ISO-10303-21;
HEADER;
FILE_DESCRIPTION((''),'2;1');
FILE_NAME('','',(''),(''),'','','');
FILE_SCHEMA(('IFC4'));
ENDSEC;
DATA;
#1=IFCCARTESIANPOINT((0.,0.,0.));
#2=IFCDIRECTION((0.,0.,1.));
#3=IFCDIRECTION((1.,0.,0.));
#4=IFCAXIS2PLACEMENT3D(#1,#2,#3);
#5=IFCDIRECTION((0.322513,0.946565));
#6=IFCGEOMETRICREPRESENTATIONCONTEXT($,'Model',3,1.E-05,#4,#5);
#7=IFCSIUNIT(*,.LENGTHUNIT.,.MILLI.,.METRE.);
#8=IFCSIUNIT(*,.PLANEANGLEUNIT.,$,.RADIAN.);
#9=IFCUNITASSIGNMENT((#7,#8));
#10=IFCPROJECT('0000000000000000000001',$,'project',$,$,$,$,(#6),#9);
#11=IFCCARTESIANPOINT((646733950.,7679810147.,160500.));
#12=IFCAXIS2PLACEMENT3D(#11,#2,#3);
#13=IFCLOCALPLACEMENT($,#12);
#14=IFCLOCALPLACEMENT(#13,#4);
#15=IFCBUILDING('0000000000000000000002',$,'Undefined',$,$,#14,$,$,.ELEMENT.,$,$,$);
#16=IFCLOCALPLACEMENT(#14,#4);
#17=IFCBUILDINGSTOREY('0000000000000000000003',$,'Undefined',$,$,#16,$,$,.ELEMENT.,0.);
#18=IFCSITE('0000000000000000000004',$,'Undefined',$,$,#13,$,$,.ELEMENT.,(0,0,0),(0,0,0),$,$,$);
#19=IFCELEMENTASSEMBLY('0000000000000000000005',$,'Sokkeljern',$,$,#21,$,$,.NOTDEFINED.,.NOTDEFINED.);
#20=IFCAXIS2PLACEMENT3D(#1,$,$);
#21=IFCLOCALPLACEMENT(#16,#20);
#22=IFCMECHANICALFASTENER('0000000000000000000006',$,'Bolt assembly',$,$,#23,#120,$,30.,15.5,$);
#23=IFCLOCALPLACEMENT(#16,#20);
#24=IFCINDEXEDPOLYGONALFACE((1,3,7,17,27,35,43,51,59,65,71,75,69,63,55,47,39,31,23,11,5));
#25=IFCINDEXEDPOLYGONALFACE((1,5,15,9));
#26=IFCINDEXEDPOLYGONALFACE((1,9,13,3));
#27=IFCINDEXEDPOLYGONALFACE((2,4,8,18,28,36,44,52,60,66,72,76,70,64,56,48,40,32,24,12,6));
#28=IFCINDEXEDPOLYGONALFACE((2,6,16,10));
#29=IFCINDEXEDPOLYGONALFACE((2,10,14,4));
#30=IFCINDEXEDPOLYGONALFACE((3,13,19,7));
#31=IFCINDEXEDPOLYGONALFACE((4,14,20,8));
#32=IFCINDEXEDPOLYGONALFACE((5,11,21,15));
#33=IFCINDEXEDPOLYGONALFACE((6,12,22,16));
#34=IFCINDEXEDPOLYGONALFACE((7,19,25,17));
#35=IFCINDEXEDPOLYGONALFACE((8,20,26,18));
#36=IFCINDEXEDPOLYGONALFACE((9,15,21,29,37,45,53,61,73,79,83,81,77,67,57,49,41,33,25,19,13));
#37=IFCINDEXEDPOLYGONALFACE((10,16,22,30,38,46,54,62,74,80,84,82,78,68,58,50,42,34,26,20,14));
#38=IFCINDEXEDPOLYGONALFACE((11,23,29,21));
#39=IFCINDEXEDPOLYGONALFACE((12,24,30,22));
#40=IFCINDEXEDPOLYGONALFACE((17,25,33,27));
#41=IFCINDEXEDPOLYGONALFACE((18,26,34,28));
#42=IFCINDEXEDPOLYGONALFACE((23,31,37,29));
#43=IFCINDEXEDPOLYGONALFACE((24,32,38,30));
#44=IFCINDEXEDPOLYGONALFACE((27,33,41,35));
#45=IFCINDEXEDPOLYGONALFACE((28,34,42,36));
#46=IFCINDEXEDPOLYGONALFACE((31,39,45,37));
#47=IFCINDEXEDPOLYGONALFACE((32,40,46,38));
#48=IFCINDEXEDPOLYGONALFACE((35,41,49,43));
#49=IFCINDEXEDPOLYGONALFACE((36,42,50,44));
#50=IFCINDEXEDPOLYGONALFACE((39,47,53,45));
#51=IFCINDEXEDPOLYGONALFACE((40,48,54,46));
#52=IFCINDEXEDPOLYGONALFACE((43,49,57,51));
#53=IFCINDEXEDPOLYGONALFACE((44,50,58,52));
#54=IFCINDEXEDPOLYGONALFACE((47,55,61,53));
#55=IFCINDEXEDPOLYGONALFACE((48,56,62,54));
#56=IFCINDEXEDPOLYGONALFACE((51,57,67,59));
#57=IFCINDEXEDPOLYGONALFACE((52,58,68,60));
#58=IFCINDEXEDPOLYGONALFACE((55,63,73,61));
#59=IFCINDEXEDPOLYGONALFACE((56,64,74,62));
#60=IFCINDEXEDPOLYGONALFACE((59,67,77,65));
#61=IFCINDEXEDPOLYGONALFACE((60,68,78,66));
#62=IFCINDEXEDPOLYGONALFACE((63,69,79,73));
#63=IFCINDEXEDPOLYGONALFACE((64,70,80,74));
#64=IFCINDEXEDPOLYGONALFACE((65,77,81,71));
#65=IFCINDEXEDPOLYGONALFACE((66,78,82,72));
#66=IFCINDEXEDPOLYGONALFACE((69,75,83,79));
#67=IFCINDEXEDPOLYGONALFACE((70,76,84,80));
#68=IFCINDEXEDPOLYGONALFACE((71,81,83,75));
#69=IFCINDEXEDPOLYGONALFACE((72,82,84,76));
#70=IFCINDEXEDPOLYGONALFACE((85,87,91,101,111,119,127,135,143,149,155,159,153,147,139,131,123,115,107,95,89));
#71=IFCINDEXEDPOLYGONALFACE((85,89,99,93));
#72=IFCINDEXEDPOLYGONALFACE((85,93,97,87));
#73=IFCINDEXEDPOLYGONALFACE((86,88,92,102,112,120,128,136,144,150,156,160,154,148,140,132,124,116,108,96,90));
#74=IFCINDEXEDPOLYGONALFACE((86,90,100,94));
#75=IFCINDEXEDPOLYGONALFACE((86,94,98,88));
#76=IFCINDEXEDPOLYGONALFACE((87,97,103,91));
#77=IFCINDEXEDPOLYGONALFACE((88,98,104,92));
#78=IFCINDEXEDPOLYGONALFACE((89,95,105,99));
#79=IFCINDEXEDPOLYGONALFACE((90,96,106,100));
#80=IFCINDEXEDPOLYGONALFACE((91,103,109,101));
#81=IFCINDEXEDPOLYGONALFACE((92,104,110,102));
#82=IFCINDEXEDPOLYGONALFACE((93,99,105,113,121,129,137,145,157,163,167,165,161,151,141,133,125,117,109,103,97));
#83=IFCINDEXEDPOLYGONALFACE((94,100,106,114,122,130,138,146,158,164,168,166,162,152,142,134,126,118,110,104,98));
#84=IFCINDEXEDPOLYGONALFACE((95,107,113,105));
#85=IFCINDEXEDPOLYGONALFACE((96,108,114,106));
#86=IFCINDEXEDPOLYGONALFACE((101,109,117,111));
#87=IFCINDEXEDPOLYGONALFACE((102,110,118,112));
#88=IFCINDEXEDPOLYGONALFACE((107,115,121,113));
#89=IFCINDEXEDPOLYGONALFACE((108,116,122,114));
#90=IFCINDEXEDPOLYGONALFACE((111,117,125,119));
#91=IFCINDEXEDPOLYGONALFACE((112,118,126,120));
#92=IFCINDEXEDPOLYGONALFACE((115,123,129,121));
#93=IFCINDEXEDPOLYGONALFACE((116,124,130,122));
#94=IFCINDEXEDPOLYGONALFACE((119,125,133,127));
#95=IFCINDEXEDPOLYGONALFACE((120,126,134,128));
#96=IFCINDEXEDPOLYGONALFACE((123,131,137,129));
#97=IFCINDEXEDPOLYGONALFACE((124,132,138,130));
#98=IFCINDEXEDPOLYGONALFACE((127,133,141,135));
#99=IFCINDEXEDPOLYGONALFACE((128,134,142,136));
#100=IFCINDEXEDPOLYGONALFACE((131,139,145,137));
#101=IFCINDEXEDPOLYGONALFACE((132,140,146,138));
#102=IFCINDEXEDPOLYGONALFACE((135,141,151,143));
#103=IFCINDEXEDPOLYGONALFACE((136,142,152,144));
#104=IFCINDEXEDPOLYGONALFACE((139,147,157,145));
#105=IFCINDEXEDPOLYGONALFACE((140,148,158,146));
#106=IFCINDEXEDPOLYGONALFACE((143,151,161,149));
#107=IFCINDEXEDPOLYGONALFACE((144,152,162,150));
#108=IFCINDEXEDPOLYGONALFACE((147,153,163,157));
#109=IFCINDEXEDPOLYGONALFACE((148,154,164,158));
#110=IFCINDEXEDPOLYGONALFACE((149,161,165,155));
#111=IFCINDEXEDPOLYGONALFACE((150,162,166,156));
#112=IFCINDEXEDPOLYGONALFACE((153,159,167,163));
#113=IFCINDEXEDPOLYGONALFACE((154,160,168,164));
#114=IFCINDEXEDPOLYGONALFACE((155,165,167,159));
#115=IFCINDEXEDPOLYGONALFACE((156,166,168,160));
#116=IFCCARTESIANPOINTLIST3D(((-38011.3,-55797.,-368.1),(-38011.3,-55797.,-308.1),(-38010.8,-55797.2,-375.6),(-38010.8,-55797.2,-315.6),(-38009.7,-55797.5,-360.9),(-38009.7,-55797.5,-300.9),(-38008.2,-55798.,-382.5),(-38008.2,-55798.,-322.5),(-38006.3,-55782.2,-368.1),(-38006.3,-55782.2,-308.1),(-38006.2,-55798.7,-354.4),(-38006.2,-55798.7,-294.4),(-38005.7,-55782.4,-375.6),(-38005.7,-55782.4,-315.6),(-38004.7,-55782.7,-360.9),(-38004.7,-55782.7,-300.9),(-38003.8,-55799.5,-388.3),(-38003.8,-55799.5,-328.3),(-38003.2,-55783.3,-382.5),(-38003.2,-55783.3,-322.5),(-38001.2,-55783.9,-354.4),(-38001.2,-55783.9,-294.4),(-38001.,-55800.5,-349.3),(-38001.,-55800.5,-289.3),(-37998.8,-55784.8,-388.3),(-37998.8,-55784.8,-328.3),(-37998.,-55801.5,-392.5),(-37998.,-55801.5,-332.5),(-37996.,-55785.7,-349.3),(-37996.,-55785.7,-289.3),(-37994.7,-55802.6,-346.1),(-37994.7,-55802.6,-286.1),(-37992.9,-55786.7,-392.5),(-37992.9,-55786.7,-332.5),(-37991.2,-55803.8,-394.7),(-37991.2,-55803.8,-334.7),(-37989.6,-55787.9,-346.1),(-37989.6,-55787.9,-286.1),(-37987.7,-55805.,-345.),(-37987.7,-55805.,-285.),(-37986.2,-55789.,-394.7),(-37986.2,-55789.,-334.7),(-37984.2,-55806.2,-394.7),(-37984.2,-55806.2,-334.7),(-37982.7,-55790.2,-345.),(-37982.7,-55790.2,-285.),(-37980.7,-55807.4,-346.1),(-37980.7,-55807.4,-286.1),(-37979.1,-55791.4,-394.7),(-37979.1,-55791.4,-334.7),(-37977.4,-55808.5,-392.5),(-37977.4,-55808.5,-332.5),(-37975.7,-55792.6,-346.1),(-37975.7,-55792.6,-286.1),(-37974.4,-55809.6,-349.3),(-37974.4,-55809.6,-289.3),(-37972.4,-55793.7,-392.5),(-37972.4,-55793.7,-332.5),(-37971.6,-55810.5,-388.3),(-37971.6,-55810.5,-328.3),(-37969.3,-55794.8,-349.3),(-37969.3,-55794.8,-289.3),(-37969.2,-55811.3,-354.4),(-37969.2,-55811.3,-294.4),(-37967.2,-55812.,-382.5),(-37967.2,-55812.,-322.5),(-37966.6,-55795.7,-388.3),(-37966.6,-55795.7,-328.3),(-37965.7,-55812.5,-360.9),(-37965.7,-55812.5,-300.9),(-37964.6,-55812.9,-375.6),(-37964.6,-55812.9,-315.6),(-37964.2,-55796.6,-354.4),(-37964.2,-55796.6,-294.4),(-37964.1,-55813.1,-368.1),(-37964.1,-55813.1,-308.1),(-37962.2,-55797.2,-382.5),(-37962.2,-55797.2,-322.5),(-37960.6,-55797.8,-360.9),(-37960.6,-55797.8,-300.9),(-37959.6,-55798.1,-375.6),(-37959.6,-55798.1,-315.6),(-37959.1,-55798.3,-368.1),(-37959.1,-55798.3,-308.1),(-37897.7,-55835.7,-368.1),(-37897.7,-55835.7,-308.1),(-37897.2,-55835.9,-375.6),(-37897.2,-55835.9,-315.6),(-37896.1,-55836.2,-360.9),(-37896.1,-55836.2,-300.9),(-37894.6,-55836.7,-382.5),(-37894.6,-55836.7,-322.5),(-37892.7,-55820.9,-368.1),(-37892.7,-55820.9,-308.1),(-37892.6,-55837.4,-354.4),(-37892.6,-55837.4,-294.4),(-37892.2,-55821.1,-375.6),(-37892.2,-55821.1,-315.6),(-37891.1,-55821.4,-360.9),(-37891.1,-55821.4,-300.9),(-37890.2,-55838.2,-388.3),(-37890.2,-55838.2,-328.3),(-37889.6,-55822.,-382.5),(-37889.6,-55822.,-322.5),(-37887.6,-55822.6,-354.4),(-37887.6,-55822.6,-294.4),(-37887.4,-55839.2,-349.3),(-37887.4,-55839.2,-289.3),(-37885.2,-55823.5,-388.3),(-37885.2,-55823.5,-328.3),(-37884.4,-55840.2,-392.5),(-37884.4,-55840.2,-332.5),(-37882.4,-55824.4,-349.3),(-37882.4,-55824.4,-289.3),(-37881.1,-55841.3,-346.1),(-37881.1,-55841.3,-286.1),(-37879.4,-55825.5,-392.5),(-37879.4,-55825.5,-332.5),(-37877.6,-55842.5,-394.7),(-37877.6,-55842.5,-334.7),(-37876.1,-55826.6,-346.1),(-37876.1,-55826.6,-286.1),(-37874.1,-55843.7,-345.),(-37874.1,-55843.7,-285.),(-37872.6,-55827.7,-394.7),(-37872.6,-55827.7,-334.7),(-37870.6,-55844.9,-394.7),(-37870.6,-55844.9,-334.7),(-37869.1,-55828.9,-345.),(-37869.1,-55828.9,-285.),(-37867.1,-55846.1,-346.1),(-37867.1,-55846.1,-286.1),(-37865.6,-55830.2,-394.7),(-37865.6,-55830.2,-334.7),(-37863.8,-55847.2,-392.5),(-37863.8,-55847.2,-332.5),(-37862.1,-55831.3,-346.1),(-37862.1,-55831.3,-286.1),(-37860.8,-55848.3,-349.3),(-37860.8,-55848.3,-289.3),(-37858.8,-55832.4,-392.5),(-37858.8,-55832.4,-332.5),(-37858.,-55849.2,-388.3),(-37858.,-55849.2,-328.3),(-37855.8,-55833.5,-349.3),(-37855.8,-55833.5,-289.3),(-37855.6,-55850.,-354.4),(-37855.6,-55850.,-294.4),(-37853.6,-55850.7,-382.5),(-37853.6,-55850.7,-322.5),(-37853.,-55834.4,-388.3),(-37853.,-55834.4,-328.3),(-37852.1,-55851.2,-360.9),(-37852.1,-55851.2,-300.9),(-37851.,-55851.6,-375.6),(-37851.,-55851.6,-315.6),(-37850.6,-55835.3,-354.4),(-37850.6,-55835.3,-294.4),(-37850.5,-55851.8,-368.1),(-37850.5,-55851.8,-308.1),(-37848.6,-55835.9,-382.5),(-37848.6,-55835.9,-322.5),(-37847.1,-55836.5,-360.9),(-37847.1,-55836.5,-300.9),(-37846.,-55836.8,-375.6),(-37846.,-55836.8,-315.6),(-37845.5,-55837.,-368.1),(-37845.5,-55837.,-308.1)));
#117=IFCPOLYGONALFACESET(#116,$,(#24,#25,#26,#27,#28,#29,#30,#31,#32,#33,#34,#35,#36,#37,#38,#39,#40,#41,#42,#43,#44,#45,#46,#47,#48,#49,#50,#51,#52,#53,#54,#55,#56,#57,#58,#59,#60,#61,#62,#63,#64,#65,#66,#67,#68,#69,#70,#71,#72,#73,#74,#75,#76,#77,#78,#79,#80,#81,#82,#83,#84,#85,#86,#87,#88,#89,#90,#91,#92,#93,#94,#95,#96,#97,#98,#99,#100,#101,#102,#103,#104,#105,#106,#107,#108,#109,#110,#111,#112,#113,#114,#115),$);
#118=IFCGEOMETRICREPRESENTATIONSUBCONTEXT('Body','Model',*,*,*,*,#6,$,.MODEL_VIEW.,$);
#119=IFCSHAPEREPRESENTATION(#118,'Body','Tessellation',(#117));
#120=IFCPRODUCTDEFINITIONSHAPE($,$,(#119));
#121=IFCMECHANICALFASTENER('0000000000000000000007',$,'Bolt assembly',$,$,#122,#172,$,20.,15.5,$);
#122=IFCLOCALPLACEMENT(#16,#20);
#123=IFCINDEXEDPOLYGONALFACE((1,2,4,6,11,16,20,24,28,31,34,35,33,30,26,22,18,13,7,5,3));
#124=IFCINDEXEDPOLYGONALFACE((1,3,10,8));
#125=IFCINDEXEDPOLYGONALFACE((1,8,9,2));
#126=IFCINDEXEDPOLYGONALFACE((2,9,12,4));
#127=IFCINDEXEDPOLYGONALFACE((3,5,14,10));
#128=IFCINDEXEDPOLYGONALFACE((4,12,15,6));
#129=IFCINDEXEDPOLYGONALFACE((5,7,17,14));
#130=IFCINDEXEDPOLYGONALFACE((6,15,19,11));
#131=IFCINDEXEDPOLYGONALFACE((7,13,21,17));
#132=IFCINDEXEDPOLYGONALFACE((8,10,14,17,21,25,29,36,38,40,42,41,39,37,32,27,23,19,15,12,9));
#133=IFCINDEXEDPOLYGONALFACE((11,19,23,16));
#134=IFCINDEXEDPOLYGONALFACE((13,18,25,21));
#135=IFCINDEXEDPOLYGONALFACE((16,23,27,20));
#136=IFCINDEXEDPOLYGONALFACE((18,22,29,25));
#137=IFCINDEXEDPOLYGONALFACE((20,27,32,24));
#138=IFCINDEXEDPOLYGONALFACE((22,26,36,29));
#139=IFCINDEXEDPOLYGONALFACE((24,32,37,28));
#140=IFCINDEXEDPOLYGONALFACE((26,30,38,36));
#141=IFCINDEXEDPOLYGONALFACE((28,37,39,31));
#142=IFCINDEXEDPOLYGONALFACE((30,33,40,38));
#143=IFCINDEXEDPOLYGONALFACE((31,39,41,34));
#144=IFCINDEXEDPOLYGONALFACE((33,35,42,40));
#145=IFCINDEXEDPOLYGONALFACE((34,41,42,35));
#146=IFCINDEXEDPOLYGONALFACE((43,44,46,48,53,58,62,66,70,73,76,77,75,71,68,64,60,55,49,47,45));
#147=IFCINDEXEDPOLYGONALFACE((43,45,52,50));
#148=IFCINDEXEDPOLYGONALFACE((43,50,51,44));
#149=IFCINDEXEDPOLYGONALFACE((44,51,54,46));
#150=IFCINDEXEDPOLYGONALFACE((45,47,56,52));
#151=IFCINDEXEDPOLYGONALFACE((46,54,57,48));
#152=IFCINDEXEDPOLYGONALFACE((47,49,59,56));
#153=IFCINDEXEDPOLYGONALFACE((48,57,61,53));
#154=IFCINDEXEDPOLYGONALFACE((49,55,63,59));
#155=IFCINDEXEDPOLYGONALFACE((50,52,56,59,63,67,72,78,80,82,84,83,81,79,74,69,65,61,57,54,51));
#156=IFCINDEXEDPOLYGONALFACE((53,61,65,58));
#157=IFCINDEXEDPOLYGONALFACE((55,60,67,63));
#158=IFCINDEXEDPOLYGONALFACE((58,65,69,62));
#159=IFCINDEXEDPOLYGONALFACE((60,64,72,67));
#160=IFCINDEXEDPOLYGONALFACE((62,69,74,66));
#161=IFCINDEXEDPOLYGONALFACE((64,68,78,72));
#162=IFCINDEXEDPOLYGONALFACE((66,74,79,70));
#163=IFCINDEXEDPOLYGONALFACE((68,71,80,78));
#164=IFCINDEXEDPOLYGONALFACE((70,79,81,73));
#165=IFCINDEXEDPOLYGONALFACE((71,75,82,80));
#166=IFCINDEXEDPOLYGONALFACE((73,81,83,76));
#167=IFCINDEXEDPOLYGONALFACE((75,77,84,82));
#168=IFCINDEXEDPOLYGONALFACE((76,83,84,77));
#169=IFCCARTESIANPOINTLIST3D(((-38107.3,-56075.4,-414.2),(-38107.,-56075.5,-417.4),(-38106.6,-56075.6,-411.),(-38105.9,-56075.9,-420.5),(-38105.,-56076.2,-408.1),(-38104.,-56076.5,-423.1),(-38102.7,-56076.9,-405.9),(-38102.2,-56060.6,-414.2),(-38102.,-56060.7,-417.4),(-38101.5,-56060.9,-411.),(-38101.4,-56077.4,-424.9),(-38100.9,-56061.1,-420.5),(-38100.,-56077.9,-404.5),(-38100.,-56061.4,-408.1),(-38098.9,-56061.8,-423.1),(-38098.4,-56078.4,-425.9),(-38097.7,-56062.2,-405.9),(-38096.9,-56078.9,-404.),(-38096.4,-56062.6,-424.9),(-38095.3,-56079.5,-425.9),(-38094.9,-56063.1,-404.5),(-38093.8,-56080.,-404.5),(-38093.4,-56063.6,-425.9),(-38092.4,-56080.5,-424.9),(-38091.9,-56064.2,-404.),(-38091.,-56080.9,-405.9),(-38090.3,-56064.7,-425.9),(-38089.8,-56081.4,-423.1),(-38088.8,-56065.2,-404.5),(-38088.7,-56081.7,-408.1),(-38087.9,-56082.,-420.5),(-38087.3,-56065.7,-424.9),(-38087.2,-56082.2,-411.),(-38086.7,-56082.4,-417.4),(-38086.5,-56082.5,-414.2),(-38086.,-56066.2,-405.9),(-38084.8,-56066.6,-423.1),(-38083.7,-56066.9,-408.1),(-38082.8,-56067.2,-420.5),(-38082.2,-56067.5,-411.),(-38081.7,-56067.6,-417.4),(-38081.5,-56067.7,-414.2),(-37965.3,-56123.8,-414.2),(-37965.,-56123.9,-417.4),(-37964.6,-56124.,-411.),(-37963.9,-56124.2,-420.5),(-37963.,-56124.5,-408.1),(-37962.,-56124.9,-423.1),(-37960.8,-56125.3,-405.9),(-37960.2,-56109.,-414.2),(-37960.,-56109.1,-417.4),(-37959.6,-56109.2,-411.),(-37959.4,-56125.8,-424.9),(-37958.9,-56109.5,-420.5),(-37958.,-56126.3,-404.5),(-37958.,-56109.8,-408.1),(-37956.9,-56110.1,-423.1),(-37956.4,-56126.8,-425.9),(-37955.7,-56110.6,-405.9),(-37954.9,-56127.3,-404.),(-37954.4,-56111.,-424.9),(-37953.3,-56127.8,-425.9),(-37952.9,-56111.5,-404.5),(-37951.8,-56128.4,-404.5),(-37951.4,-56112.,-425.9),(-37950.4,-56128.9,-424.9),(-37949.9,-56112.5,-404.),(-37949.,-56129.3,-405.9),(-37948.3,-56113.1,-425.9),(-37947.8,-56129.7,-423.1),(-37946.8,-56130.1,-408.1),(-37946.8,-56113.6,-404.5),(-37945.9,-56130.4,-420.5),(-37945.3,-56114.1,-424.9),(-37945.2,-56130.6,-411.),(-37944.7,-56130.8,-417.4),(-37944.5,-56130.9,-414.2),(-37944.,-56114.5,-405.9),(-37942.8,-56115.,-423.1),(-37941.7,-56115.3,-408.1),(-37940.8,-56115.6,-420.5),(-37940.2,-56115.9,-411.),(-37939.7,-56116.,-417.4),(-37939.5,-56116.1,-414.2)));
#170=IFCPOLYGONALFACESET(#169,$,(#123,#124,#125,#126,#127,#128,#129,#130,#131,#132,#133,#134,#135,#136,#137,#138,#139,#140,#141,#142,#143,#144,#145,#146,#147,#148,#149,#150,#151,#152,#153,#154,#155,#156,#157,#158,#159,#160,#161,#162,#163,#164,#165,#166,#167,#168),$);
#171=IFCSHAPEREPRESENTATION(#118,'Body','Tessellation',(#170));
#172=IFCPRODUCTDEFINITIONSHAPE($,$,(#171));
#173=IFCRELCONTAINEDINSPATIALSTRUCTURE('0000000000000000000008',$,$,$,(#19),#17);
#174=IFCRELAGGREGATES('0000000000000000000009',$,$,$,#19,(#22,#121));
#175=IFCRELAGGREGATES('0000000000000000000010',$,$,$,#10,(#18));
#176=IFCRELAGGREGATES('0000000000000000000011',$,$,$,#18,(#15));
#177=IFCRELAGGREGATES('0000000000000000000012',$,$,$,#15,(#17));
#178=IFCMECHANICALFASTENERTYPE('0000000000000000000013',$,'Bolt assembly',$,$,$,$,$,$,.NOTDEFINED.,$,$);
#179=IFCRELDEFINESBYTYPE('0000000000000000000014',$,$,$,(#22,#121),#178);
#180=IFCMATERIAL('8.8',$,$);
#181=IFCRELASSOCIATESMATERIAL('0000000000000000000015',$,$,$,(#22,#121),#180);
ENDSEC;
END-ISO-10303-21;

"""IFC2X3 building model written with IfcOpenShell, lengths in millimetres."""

from ifc_helpers import new_model, si_unit, direction, frame, origin_with_axes, origin_2d_with_axis, place, context, subcontext, project, spatial, circle, extrude, source, transform, mapped, material, type_object, element, aggregate, save


model = new_model("IFC2X3")

# Units and contexts
model_context = context("Model", 3, precision=1e-05, world=origin_with_axes(), true_north=direction((0.322513, 0.946565)))
body_context = subcontext(model_context, "Body", "Model", "MODEL_VIEW")
ifc_project = project(units=[si_unit("LENGTHUNIT", "METRE", prefix="MILLI"), si_unit("PLANEANGLEUNIT", "RADIAN")], contexts=[model_context])

# Site, building, storey
site_placement = place(None, frame((646733950.0, 7679810147.0, 160500.0), z_axis=(0.0, 0.0, 1.0), x_axis=(1.0, 0.0, 0.0)))
site = spatial("IfcSite", under=ifc_project, at=site_placement, Name="Undefined", CompositionType="ELEMENT", RefLatitude=(0, 0, 0), RefLongitude=(0, 0, 0))
building_placement = place(site_placement, origin_with_axes())
building = spatial("IfcBuilding", under=site, at=building_placement, Name="Undefined", CompositionType="ELEMENT")
storey_placement = place(building_placement, origin_with_axes())
storey = spatial("IfcBuildingStorey", under=building, at=storey_placement, Name="Undefined", CompositionType="ELEMENT", Elevation=0.0)

# Element assembly
assembly_1_placement = place(storey_placement, origin_with_axes())
assembly_1 = element("IfcElementAssembly", 1, at=assembly_1_placement, inside=storey, Name="Sokkeljern", AssemblyPlace="NOTDEFINED", PredefinedType="NOTDEFINED")

# Mechanical fasteners
ifc_material_1 = material(Name="8.8")
mechanical_fastener_type = type_object("IfcMechanicalFastenerType", Name="Bolt assembly")
shared_shape_1 = source(origin_with_axes(), body_context, "Body", "SweptSolid", [
    extrude(circle(Radius=25.0, at=origin_2d_with_axis()), frame((0.0, 0.0, 0.0), z_axis=(0.0, 1.0, 0.0), x_axis=(1.0, 0.0, 0.0)), (0.0, 0.0, 1.0), 15.6),
])
mechanical_fastener_1_placement = place(assembly_1_placement, frame((-37925.9, -55809.6, -370.0), z_axis=(0.946565, -0.322513, 0.0), x_axis=(0.0, 0.0, 1.0)))
mechanical_fastener_1 = element("IfcMechanicalFastener", 2, at=mechanical_fastener_1_placement, type_object=mechanical_fastener_type, material=ifc_material_1, Name="Bolt assembly", NominalDiameter=30.0, NominalLength=15.5, context=body_context, shape_type="MappedRepresentation", body=[
    mapped(shared_shape_1, transform((0.0, 0.0, -60.0))),
    mapped(shared_shape_1, transform((60.0, 0.0, -60.0))),
    mapped(shared_shape_1, transform((0.0, 0.0, 60.0))),
    mapped(shared_shape_1, transform((60.0, 0.0, 60.0))),
])
shared_shape_2 = source(origin_with_axes(), body_context, "Body", "SweptSolid", [
    extrude(circle(Radius=11.0, at=origin_2d_with_axis()), frame((0.0, -15.5, 0.0), z_axis=(0.0, 1.0, 0.0), x_axis=(1.0, 0.0, 0.0)), (0.0, 0.0, 1.0), 15.6),
])
mechanical_fastener_2_placement = place(assembly_1_placement, frame((-38025.9, -56103.0, -415.0), z_axis=(0.946565, -0.322513, 0.0), x_axis=(0.0, 0.0, 1.0)))
mechanical_fastener_2 = element("IfcMechanicalFastener", 3, at=mechanical_fastener_2_placement, type_object=mechanical_fastener_type, material=ifc_material_1, Name="Bolt assembly", NominalDiameter=20.0, NominalLength=15.5, context=body_context, shape_type="MappedRepresentation", body=[
    mapped(shared_shape_2, transform((0.0, 0.0, -75.0))),
    mapped(shared_shape_2, transform((0.0, 0.0, 75.0))),
])
aggregate(assembly_1, [mechanical_fastener_1, mechanical_fastener_2])

save(model, "model.ifc")
